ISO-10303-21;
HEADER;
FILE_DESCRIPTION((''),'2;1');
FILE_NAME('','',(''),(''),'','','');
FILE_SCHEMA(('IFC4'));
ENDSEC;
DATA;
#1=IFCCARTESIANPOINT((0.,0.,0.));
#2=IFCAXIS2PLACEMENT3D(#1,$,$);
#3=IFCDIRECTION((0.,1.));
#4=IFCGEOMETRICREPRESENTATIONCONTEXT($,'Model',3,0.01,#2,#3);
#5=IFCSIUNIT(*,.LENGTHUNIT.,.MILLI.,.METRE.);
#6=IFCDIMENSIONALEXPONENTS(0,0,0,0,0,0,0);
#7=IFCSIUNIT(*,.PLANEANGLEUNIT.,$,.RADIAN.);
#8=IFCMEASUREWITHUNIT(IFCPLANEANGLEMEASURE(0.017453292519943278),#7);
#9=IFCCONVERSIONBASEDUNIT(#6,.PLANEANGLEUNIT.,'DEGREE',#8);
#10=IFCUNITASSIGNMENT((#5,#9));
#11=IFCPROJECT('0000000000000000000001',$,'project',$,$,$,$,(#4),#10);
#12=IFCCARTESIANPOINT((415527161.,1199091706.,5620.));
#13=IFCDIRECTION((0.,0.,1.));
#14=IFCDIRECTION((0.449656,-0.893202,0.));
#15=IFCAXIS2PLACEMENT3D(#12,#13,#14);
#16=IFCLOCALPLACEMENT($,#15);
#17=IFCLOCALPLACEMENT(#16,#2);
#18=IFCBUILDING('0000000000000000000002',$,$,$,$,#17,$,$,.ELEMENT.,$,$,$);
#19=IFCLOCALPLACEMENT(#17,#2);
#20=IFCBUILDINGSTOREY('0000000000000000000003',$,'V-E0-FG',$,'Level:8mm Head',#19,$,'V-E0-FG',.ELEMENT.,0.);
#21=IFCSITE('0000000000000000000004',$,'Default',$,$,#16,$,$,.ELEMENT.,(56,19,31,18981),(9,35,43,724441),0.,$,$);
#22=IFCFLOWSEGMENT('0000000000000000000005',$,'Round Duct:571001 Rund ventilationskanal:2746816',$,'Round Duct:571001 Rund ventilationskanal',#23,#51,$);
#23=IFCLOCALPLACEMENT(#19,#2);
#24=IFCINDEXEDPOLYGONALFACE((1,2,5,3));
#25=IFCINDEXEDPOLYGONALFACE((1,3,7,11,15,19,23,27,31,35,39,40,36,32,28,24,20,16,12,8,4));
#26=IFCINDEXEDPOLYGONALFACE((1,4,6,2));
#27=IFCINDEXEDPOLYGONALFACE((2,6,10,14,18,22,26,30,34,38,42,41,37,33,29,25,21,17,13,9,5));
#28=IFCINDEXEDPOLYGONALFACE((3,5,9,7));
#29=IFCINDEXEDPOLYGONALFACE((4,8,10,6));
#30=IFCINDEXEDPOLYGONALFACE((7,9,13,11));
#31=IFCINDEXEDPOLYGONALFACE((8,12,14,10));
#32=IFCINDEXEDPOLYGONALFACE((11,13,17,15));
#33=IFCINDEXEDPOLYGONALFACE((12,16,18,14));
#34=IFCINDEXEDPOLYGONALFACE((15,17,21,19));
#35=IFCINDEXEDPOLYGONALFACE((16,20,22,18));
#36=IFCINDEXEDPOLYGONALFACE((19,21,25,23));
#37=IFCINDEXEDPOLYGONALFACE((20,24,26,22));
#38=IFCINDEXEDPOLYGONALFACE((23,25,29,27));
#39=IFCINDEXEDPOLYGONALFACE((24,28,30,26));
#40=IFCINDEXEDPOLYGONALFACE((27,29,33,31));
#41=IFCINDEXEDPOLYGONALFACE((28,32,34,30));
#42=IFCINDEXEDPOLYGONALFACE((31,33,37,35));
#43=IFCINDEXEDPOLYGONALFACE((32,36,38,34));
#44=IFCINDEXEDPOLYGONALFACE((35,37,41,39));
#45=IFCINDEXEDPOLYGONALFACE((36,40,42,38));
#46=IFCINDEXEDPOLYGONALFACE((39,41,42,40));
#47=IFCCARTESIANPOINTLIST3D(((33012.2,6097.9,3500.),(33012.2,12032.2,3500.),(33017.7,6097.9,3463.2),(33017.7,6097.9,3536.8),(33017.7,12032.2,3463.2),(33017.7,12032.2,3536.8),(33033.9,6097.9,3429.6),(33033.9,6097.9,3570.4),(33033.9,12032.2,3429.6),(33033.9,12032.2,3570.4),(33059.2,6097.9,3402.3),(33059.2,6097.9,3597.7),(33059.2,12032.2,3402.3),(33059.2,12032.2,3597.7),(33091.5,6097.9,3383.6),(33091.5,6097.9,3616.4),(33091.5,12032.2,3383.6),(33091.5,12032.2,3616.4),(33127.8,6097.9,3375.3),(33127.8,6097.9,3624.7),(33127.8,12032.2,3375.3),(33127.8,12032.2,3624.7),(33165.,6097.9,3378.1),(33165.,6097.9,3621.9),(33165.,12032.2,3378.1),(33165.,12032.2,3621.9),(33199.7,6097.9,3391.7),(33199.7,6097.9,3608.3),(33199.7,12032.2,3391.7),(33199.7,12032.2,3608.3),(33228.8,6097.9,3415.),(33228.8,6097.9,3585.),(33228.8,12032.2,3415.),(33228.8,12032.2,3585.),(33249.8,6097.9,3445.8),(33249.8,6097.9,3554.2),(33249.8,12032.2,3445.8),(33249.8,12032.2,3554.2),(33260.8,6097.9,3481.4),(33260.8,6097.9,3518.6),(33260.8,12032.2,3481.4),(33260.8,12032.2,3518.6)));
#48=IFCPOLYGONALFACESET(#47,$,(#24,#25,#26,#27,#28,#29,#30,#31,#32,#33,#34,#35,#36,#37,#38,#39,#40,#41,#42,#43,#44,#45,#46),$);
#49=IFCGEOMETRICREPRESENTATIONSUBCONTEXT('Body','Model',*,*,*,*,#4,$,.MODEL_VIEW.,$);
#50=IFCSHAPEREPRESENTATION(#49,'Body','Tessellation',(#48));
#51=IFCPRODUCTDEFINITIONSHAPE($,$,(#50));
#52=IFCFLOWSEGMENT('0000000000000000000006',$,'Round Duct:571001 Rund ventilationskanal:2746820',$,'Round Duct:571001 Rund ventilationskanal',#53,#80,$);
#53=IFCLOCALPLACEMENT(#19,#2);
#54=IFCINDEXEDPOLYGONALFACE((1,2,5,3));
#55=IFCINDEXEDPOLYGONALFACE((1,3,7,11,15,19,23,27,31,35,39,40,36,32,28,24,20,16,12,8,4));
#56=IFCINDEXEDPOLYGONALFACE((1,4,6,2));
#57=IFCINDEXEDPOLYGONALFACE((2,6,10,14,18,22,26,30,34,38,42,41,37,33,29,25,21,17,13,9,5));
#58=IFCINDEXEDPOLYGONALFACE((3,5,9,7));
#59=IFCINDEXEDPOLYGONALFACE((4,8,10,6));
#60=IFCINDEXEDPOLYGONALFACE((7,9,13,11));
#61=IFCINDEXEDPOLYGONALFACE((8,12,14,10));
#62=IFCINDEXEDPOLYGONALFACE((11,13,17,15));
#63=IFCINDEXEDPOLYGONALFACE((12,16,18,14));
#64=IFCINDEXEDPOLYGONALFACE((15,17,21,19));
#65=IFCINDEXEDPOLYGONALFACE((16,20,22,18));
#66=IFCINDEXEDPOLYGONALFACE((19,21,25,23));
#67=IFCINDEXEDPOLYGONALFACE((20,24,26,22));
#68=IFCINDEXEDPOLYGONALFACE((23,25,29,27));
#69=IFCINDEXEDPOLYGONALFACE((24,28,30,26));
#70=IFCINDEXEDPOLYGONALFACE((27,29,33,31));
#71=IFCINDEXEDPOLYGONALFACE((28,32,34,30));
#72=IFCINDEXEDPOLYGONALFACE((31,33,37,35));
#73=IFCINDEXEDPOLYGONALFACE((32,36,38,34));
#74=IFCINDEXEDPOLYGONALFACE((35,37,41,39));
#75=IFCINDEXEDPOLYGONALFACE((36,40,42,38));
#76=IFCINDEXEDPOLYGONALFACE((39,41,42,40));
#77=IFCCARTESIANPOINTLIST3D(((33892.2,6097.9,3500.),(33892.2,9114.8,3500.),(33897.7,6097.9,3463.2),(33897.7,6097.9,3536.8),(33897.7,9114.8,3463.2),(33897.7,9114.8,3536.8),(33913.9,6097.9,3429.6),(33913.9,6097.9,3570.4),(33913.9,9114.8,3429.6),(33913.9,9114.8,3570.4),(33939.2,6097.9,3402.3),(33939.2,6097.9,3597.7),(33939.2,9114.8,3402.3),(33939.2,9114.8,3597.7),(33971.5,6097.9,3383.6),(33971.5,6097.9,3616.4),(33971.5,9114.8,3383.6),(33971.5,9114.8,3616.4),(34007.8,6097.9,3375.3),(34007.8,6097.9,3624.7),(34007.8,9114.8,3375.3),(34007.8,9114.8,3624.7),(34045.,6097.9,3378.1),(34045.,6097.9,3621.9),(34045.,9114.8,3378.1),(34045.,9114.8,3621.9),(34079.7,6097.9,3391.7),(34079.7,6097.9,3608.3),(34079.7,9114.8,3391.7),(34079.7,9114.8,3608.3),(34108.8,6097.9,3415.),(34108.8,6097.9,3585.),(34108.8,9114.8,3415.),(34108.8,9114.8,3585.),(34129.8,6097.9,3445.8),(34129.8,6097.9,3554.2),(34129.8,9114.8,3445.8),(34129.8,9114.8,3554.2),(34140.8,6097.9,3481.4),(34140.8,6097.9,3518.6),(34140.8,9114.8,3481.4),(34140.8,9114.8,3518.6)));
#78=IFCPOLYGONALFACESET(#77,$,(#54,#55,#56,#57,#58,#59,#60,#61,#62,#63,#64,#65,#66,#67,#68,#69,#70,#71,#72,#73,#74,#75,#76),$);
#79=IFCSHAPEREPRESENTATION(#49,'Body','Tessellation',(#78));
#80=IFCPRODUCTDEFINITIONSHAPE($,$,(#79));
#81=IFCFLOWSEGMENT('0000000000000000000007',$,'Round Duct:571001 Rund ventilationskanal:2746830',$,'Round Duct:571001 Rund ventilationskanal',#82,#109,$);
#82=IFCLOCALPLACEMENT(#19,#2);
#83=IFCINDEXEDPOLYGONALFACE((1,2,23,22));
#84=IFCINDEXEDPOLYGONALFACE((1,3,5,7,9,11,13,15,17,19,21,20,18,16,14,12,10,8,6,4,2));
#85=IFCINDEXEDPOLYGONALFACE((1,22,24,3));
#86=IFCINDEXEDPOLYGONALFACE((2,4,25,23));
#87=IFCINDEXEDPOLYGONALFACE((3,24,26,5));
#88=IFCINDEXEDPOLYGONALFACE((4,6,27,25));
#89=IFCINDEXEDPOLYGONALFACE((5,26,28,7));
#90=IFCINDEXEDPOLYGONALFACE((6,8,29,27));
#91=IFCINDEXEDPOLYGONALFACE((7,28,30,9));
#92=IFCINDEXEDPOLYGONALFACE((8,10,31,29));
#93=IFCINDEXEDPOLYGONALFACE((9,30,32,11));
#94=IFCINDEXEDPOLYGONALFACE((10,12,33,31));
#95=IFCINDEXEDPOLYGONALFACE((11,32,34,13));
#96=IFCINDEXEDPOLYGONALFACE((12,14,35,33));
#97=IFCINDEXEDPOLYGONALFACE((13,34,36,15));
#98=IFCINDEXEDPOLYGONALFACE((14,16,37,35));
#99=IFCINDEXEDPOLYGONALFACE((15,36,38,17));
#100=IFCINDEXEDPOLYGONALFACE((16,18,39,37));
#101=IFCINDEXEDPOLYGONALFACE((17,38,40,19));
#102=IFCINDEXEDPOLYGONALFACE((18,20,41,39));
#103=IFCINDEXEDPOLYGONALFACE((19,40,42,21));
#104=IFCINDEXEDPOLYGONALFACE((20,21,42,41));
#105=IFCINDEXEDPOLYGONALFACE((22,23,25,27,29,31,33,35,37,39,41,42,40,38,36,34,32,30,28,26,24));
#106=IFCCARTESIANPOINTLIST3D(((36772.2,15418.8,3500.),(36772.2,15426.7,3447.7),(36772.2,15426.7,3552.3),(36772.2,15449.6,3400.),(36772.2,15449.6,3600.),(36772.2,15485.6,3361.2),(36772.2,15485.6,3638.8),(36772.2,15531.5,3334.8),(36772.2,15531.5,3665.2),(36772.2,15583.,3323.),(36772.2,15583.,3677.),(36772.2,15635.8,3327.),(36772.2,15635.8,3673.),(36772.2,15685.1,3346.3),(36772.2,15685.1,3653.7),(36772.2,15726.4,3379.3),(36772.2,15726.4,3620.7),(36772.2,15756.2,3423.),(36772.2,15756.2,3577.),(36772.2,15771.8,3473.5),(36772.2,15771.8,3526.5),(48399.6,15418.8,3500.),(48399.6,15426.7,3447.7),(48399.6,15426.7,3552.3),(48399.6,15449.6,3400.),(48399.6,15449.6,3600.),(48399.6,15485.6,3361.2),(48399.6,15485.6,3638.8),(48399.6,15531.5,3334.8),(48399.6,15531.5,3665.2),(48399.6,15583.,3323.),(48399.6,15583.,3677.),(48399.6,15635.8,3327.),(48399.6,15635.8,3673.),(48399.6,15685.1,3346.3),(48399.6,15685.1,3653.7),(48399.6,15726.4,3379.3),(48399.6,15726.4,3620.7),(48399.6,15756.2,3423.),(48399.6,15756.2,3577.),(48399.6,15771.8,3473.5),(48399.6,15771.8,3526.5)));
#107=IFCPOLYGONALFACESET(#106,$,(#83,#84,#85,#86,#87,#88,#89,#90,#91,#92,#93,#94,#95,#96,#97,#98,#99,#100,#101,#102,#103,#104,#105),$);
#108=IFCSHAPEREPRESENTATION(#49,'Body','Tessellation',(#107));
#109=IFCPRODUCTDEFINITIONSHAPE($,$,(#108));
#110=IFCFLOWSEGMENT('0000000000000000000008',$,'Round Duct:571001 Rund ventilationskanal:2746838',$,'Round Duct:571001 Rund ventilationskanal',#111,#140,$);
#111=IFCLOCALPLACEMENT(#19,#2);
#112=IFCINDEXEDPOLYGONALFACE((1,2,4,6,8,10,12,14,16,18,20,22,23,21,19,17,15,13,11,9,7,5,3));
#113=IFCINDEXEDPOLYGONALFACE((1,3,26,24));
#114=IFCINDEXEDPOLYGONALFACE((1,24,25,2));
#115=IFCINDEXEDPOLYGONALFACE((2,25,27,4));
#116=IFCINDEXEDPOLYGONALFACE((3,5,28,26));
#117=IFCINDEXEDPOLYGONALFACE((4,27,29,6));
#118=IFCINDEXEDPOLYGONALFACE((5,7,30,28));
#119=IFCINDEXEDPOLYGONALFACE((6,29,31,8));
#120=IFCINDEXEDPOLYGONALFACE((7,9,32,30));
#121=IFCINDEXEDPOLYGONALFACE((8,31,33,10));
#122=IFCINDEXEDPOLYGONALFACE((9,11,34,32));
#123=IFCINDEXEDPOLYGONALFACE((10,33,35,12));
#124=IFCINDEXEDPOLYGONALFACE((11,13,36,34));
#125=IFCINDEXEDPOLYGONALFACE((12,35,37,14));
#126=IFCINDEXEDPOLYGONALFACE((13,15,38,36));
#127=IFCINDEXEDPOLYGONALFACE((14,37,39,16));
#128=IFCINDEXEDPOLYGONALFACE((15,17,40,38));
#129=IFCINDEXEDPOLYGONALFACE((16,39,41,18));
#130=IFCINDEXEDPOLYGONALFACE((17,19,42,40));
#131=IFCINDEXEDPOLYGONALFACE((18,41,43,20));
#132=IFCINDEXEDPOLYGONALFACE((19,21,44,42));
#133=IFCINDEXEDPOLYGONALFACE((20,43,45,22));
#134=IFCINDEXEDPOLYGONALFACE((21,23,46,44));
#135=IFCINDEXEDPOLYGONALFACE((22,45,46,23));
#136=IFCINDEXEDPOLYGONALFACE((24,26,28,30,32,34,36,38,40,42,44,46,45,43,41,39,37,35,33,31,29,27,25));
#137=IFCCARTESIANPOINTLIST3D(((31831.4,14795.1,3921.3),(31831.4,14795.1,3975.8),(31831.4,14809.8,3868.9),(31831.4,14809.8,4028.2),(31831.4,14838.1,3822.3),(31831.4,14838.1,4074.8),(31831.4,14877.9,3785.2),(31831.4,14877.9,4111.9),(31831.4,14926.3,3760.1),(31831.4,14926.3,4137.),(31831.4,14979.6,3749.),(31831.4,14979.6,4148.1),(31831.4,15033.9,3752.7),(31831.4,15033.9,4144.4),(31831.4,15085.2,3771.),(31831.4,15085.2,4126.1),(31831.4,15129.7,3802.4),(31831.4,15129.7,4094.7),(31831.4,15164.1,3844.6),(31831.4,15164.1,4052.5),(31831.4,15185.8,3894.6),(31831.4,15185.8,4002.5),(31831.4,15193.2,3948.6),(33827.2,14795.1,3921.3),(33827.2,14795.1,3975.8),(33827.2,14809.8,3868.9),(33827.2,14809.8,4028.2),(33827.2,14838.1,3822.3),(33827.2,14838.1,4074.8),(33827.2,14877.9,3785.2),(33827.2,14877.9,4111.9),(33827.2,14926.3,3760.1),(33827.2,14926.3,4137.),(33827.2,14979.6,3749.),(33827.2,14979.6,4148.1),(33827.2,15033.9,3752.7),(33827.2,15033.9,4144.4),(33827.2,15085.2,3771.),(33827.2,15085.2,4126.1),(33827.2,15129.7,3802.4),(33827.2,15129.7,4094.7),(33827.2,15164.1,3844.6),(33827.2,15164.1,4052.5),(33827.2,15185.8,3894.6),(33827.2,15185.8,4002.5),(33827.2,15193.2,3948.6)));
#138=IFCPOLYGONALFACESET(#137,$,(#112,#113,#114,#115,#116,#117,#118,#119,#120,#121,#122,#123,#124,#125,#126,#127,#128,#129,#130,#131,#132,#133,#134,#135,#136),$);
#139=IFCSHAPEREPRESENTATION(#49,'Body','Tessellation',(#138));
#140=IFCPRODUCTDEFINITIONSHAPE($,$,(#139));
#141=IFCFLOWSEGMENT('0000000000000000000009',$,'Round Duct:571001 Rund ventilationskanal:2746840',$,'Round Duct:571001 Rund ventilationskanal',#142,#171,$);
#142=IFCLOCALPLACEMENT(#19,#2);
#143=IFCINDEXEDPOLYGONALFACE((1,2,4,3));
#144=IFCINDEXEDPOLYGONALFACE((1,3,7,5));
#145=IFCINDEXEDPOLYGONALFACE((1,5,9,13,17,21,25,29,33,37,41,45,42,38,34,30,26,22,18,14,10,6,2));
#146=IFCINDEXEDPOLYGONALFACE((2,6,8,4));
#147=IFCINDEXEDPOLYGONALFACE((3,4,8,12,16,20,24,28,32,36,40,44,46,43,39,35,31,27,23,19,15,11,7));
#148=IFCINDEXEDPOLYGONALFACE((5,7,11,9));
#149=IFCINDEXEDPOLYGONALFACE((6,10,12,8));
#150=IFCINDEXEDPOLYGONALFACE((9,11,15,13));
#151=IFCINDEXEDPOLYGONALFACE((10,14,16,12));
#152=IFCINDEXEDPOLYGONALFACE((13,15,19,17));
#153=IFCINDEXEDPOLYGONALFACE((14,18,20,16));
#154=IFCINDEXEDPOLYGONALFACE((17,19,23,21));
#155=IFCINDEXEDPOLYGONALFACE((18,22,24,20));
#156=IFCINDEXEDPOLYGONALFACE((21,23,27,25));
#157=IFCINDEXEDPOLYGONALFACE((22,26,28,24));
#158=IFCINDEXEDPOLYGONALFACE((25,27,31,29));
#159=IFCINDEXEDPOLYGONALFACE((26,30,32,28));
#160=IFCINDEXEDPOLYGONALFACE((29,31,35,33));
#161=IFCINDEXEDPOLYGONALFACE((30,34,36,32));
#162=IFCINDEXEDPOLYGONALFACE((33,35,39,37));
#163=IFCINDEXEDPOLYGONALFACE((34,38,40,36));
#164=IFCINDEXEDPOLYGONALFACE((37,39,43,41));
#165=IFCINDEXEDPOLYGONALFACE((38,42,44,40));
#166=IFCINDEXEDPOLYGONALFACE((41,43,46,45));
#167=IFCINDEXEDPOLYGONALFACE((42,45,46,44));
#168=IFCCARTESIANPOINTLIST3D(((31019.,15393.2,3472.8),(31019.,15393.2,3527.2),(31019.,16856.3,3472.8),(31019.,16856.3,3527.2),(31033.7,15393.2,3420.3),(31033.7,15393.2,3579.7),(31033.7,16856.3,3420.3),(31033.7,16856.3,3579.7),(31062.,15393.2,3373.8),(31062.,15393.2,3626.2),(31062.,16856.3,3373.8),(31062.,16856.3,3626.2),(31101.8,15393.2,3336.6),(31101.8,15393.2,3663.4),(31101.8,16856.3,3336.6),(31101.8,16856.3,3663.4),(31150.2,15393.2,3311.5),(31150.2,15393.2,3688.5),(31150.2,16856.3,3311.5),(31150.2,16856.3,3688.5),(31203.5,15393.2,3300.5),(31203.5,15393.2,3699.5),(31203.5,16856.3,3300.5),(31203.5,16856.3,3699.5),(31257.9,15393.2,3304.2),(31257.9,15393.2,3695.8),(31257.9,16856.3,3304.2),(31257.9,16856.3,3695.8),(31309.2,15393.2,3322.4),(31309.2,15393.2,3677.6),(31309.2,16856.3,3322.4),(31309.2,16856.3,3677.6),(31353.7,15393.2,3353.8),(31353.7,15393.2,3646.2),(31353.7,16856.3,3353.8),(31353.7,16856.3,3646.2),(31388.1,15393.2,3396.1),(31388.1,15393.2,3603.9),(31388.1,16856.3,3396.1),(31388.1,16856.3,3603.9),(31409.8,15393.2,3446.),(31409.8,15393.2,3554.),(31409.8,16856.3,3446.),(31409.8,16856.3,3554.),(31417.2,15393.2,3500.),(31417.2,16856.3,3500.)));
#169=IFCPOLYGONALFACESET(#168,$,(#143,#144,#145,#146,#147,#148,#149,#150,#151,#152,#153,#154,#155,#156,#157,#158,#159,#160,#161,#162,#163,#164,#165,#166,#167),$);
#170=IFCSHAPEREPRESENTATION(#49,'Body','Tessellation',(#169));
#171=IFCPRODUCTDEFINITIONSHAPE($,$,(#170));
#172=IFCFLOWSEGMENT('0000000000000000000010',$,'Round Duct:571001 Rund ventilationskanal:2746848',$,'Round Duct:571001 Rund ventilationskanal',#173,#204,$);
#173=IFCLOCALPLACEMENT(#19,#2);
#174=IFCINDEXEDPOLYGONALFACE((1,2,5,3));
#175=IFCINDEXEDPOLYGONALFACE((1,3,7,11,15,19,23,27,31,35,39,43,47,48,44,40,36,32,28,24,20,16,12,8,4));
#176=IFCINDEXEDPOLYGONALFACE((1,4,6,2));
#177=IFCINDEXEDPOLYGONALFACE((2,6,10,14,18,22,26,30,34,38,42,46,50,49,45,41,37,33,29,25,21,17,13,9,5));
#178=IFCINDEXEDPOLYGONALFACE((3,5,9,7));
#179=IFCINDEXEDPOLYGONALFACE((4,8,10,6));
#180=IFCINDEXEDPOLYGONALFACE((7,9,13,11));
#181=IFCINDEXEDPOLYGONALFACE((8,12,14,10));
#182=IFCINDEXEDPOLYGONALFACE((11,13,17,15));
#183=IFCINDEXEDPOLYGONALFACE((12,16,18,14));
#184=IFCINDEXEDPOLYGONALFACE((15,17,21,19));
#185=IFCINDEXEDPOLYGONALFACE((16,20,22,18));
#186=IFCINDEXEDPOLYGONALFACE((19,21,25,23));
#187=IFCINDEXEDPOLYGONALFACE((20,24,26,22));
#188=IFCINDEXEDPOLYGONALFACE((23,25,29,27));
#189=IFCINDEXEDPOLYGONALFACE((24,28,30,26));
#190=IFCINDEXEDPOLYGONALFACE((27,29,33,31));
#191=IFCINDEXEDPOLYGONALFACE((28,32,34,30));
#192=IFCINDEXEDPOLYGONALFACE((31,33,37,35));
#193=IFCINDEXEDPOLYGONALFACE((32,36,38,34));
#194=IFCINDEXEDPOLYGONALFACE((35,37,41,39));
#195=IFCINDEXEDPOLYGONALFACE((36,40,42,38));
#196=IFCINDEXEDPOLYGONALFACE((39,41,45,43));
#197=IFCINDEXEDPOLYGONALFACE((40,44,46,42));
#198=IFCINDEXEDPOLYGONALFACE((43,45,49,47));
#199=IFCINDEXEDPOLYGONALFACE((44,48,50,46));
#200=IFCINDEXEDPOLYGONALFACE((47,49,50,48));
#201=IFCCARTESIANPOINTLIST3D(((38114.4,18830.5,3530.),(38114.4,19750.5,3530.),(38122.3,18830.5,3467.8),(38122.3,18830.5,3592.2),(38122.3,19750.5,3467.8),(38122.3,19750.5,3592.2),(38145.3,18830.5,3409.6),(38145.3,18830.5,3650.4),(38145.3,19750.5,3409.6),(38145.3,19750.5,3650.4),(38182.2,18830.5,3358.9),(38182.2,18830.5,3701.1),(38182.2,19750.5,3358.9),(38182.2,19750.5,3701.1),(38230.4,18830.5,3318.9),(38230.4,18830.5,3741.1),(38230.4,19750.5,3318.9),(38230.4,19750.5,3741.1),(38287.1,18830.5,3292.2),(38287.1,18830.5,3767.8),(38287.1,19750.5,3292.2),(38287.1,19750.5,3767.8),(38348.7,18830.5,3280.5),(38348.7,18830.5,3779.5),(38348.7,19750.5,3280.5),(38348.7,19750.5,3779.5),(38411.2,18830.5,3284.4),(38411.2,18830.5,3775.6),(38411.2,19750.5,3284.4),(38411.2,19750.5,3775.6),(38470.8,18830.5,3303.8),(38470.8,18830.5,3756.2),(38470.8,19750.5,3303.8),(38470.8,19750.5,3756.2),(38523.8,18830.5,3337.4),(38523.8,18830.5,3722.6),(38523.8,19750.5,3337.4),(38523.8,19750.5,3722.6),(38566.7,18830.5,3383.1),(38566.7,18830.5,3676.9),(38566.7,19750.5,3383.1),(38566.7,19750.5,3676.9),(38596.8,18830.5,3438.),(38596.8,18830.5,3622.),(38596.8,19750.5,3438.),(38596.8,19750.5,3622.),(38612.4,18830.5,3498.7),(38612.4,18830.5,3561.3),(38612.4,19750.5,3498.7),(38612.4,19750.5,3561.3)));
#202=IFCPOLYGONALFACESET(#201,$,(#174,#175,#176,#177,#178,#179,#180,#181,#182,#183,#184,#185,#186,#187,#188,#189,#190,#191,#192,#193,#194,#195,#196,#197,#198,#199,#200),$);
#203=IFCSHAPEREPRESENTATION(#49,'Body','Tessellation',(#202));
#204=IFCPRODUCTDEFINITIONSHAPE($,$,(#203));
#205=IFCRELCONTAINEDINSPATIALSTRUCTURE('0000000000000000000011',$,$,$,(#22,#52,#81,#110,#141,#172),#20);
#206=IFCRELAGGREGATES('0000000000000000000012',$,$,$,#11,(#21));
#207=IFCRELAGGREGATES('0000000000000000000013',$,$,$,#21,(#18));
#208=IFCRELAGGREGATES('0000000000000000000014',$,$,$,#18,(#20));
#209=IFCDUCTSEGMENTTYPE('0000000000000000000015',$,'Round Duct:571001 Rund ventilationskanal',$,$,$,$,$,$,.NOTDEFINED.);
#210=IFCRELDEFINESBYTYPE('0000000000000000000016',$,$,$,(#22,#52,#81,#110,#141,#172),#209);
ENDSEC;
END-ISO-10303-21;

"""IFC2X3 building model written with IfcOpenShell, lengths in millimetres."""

from ifc_helpers import new_model, entity, si_unit, converted_unit, direction, frame, frame_2d, origin, origin_2d_with_axis, place, context, subcontext, project, spatial, circle, extrude, type_object, element, save


model = new_model("IFC2X3")

# Units and contexts
model_context = context("Model", 3, precision=0.01, world=origin(), true_north=direction((0.0, 1.0)))
body_context = subcontext(model_context, "Body", "Model", "MODEL_VIEW")
ifc_project = project(units=[si_unit("LENGTHUNIT", "METRE", prefix="MILLI"), converted_unit("PLANEANGLEUNIT", "DEGREE", entity("IfcPlaneAngleMeasure", 0.017453292519943278), si_unit("PLANEANGLEUNIT", "RADIAN"), dimensions=[0, 0, 0, 0, 0, 0, 0])], contexts=[model_context])

# Site, building, storey
site_placement = place(None, frame((415527161.0, 1199091706.0, 5620.0), z_axis=(0.0, 0.0, 1.0), x_axis=(0.449656, -0.893202, 0.0)))
site = spatial("IfcSite", under=ifc_project, at=site_placement, Name="Default", CompositionType="ELEMENT", RefLatitude=(56, 19, 31, 18981), RefLongitude=(9, 35, 43, 724441), RefElevation=0.0)
building_placement = place(site_placement, origin())
building = spatial("IfcBuilding", under=site, at=building_placement, CompositionType="ELEMENT")
storey_placement = place(building_placement, origin())
storey = spatial("IfcBuildingStorey", under=building, at=storey_placement, Name="V-E0-FG", ObjectType="Level:8mm Head", LongName="V-E0-FG", CompositionType="ELEMENT", Elevation=0.0)

# Flow segments
duct_segment_type = type_object("IfcDuctSegmentType", Name="Round Duct:571001 Rund ventilationskanal", PredefinedType="NOTDEFINED")
flow_segment_1_placement = place(storey_placement, origin())
element("IfcFlowSegment", 1, at=flow_segment_1_placement, inside=storey, type_object=duct_segment_type, Name="Round Duct:571001 Rund ventilationskanal:2746816", ObjectType="Round Duct:571001 Rund ventilationskanal", context=body_context, shape_type="SweptSolid", body=[
    extrude(circle(Radius=125.0, at=frame_2d((0.0, 0.0), x_axis=(1.0, 0.0))), frame((33137.2, 6097.9, 3500.0), z_axis=(0.0, 1.0, 0.0), x_axis=(-1.0, 0.0, 0.0)), (0.0, 0.0, 1.0), 5934.2),
])
flow_segment_2_placement = place(storey_placement, origin())
element("IfcFlowSegment", 2, at=flow_segment_2_placement, inside=storey, type_object=duct_segment_type, Name="Round Duct:571001 Rund ventilationskanal:2746820", ObjectType="Round Duct:571001 Rund ventilationskanal", context=body_context, shape_type="SweptSolid", body=[
    extrude(circle(Radius=125.0, at=frame_2d((0.0, 0.0), x_axis=(1.0, 0.0))), frame((34017.2, 6097.9, 3500.0), z_axis=(0.0, 1.0, 0.0), x_axis=(-1.0, 0.0, 0.0)), (0.0, 0.0, 1.0), 3016.8),
])
flow_segment_3_placement = place(storey_placement, origin())
element("IfcFlowSegment", 3, at=flow_segment_3_placement, inside=storey, type_object=duct_segment_type, Name="Round Duct:571001 Rund ventilationskanal:2746830", ObjectType="Round Duct:571001 Rund ventilationskanal", context=body_context, shape_type="SweptSolid", body=[
    extrude(circle(Radius=177.5, at=frame_2d((0.0, 0.0), x_axis=(1.0, 0.0))), frame((36772.2, 15596.3, 3500.0), z_axis=(1.0, 0.0, 0.0), x_axis=(0.0, -1.0, 0.0)), (0.0, 0.0, 1.0), 11627.4),
])
flow_segment_4_placement = place(storey_placement, origin())
element("IfcFlowSegment", 4, at=flow_segment_4_placement, inside=storey, type_object=duct_segment_type, Name="Round Duct:571001 Rund ventilationskanal:2746838", ObjectType="Round Duct:571001 Rund ventilationskanal", context=body_context, shape_type="SweptSolid", body=[
    extrude(circle(Radius=200.0, at=frame_2d((0.0, 0.0), x_axis=(1.0, 0.0))), frame((31831.4, 14993.2, 3948.6), z_axis=(1.0, 0.0, 0.0), x_axis=(0.0, 1.0, 0.0)), (0.0, 0.0, 1.0), 1995.8),
])
flow_segment_5_placement = place(storey_placement, origin())
element("IfcFlowSegment", 5, at=flow_segment_5_placement, inside=storey, type_object=duct_segment_type, Name="Round Duct:571001 Rund ventilationskanal:2746840", ObjectType="Round Duct:571001 Rund ventilationskanal", context=body_context, shape_type="SweptSolid", body=[
    extrude(circle(Radius=200.0, at=origin_2d_with_axis()), frame((31217.2, 15393.2, 3500.0), z_axis=(0.0, 1.0, 0.0), x_axis=(1.0, 0.0, 0.0)), (0.0, 0.0, 1.0), 1463.1),
])
flow_segment_6_placement = place(storey_placement, origin())
element("IfcFlowSegment", 6, at=flow_segment_6_placement, inside=storey, type_object=duct_segment_type, Name="Round Duct:571001 Rund ventilationskanal:2746848", ObjectType="Round Duct:571001 Rund ventilationskanal", context=body_context, shape_type="SweptSolid", body=[
    extrude(circle(Radius=250.0, at=origin_2d_with_axis()), frame((38364.4, 18830.5, 3530.0), z_axis=(0.0, 1.0, 0.0), x_axis=(-1.0, 0.0, 0.0)), (0.0, 0.0, 1.0), 920.0),
])

save(model, "model.ifc")
